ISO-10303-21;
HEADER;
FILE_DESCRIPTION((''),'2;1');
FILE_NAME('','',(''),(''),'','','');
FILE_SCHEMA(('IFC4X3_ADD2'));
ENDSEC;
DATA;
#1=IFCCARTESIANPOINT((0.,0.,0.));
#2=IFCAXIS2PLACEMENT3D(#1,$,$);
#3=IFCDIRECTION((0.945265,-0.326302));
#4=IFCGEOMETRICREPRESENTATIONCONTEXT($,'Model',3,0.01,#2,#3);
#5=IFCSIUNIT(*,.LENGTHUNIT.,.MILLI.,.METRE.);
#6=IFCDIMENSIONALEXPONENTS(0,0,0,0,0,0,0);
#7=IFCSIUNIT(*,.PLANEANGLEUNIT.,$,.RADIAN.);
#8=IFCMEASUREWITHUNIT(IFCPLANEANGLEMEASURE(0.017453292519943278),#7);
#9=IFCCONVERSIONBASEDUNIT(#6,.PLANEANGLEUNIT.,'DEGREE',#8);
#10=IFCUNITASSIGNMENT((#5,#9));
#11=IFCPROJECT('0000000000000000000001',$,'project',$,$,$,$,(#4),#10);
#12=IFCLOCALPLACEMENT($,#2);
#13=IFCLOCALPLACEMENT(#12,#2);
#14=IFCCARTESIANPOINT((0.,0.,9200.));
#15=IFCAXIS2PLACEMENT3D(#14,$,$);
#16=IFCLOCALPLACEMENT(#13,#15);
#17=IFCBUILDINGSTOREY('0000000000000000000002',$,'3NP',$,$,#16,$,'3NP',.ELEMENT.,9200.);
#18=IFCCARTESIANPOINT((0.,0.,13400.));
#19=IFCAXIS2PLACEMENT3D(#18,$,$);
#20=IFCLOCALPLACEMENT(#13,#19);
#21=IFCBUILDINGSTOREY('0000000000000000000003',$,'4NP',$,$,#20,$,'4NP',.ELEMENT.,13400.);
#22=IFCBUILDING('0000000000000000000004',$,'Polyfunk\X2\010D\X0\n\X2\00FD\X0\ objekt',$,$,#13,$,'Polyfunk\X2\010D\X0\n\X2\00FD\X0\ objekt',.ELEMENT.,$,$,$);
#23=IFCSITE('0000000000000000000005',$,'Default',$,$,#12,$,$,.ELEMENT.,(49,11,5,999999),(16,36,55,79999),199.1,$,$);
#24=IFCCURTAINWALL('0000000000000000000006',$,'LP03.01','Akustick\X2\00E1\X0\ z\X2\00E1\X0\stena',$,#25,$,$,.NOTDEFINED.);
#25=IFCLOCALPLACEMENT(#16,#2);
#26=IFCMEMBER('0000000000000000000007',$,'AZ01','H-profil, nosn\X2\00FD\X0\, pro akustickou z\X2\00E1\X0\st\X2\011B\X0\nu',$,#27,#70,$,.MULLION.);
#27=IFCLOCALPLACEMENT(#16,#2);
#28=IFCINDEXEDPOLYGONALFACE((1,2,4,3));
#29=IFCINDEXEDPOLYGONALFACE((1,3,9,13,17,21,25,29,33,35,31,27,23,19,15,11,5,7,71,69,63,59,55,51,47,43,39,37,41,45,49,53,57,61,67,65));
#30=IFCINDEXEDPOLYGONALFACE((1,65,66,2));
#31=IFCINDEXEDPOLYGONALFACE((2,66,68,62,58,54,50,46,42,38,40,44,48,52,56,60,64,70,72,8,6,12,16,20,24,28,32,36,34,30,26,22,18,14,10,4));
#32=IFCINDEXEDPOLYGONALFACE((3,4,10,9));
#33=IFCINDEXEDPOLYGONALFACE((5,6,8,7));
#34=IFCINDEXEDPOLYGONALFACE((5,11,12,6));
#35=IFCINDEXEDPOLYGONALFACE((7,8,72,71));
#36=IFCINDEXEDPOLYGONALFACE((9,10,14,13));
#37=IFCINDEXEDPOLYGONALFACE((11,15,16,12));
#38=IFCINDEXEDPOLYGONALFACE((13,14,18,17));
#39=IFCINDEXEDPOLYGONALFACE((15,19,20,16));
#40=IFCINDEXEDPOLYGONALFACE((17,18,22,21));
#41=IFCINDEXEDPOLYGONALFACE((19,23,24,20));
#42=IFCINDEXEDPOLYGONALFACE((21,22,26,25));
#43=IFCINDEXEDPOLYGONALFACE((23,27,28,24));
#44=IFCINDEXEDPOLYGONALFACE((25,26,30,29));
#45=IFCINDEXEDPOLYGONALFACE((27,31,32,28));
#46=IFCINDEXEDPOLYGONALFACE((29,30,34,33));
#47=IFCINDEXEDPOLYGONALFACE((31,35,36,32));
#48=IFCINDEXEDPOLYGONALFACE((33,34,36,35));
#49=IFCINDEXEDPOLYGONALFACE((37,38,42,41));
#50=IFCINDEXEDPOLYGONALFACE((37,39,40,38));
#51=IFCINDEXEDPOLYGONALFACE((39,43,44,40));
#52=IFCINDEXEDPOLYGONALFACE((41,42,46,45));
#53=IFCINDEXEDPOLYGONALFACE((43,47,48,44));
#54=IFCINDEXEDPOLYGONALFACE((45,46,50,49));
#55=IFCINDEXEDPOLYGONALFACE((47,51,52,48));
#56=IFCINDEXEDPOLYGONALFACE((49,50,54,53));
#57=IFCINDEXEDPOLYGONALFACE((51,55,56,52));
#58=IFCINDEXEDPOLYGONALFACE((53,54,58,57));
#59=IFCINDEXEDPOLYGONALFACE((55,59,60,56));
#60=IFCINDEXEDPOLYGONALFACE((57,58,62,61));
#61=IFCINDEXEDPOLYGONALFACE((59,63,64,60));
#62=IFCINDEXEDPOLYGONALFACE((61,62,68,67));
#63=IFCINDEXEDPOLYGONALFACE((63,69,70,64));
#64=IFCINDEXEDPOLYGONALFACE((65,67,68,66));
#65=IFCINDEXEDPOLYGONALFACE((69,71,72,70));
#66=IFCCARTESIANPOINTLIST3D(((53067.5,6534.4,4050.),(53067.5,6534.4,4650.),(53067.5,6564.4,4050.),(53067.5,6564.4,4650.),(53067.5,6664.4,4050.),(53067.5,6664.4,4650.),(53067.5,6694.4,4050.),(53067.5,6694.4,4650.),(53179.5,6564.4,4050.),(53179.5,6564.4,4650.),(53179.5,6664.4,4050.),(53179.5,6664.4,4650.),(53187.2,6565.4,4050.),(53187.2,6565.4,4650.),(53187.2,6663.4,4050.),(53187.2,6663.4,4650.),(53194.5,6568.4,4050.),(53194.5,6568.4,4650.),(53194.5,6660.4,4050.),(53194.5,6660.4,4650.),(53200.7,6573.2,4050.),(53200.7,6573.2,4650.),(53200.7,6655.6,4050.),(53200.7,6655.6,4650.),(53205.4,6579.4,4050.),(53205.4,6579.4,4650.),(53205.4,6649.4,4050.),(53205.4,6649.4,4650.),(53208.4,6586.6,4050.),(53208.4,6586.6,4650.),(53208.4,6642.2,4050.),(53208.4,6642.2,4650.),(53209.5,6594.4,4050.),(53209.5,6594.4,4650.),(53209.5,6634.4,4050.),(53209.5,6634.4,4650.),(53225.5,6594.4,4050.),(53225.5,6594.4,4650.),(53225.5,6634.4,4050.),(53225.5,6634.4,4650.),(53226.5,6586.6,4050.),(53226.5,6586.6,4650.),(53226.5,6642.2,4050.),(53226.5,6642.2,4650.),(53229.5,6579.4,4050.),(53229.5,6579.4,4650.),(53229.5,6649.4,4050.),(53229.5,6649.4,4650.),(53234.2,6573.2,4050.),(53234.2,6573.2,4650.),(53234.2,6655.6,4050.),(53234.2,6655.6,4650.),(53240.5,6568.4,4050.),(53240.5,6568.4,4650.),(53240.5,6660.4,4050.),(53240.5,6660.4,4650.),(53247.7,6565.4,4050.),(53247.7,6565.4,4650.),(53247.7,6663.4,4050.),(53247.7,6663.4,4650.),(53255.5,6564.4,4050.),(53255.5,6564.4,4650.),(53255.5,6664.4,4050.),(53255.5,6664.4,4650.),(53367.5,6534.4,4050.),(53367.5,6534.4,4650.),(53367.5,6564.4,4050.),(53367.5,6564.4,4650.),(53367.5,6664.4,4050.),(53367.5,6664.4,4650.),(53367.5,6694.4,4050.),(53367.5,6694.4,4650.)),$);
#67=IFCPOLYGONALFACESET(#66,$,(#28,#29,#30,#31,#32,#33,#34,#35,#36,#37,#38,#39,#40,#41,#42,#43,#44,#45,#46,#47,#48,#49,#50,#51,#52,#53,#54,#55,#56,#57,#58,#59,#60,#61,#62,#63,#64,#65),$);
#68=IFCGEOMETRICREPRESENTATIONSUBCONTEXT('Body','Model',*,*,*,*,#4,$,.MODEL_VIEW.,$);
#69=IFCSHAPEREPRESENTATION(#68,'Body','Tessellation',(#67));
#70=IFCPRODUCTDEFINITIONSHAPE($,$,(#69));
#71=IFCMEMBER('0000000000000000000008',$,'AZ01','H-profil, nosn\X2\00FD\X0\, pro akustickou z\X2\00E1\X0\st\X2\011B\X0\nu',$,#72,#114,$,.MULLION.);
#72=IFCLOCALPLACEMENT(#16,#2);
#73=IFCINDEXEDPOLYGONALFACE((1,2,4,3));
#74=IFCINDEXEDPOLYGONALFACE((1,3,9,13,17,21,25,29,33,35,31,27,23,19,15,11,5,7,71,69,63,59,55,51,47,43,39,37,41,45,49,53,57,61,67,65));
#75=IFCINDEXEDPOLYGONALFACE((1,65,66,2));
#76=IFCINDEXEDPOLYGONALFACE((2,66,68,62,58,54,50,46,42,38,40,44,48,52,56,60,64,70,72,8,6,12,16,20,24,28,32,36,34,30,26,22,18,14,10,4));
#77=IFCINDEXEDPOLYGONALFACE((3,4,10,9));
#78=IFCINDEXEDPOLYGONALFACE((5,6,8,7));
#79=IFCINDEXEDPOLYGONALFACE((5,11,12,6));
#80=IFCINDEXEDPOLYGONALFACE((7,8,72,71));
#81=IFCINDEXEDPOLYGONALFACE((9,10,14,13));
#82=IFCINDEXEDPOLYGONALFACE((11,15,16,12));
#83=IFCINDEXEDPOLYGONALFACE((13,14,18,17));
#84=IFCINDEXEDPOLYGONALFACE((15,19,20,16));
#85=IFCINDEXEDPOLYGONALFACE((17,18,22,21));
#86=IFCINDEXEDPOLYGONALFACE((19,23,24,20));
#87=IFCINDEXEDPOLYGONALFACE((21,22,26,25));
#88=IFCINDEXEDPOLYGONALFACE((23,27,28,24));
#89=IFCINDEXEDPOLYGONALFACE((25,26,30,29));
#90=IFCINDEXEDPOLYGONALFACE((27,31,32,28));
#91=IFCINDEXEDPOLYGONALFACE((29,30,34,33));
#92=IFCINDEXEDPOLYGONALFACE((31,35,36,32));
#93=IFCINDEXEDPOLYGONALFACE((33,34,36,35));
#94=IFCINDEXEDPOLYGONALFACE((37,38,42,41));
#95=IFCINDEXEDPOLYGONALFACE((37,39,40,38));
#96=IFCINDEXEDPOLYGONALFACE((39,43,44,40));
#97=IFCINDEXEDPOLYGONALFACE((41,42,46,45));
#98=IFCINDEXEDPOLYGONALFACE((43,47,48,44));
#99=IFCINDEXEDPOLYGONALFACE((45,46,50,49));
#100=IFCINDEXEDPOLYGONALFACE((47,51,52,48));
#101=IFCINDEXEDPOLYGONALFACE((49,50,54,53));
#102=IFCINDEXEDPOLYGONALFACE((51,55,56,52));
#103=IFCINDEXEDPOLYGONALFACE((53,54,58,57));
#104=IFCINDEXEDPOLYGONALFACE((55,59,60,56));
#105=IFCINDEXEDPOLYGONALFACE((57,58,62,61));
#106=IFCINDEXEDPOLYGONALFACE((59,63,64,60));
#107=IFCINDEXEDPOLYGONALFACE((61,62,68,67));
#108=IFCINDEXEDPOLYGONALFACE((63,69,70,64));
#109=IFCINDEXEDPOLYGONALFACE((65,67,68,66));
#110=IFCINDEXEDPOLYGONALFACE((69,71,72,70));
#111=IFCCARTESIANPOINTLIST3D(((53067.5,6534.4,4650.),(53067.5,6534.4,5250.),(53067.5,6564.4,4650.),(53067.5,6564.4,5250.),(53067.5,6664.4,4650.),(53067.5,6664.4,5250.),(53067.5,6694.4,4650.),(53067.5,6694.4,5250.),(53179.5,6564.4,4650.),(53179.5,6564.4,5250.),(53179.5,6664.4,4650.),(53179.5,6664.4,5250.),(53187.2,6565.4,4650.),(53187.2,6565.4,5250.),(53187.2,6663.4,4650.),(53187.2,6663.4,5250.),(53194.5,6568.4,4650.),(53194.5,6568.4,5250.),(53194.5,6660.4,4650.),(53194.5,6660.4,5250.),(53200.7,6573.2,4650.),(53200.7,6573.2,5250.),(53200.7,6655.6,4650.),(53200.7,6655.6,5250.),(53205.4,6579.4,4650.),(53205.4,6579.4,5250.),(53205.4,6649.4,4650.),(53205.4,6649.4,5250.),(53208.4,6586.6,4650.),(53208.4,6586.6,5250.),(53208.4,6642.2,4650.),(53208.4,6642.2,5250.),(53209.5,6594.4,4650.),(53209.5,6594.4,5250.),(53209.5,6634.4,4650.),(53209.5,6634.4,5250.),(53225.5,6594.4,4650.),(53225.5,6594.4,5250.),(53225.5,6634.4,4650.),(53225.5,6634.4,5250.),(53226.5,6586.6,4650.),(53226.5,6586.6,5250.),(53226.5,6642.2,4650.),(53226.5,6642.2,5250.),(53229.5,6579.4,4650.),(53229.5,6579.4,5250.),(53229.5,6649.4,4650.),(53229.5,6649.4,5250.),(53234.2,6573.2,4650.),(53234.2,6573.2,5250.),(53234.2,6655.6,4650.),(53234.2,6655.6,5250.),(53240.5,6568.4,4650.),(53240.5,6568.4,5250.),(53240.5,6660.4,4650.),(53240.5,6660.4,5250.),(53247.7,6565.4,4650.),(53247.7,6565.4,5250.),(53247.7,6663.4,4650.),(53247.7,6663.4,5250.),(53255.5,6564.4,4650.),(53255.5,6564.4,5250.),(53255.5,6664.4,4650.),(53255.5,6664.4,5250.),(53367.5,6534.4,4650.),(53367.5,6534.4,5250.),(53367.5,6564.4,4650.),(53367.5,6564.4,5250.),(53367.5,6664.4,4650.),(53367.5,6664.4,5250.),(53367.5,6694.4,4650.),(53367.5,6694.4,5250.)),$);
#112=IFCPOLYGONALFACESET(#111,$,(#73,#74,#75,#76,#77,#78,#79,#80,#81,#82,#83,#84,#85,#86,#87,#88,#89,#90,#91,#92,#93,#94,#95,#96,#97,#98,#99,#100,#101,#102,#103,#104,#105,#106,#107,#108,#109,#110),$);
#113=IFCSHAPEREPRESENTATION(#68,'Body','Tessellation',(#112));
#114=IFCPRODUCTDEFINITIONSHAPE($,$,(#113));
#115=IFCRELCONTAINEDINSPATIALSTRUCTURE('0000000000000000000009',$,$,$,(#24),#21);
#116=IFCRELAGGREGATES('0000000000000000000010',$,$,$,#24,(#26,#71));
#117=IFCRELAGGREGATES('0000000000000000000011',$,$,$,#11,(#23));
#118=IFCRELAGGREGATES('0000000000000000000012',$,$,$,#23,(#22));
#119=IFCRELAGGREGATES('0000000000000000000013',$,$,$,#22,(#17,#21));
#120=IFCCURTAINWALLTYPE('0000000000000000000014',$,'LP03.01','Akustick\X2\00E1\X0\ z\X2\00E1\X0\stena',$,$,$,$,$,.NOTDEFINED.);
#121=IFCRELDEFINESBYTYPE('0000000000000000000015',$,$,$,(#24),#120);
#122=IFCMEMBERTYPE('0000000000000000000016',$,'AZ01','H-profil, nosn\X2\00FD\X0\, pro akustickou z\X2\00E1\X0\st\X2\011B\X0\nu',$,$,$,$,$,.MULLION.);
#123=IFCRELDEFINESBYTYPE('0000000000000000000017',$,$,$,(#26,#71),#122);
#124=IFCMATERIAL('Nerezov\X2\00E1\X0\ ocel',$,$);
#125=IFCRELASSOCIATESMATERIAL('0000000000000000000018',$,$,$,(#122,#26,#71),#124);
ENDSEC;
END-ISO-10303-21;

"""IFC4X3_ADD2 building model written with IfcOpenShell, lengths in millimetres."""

from ifc_helpers import new_model, entity, si_unit, converted_unit, direction, frame, frame_2d, origin, place, context, subcontext, project, spatial, polyline, circle_curve, parameter, trimmed, segment, composite_curve, outline, extrude, source, transform, mapped, material, material_profile, profile_set, profile_usage, type_object, element, aggregate, save


model = new_model("IFC4X3_ADD2")

# Units and contexts
model_context = context("Model", 3, precision=0.01, world=origin(), true_north=direction((0.945265, -0.326302)))
body_context = subcontext(model_context, "Body", "Model", "MODEL_VIEW")
ifc_project = project(units=[si_unit("LENGTHUNIT", "METRE", prefix="MILLI"), converted_unit("PLANEANGLEUNIT", "DEGREE", entity("IfcPlaneAngleMeasure", 0.017453292519943278), si_unit("PLANEANGLEUNIT", "RADIAN"), dimensions=[0, 0, 0, 0, 0, 0, 0])], contexts=[model_context])

# Site, building, storey
site_placement = place(None, origin())
site = spatial("IfcSite", under=ifc_project, at=site_placement, Name="Default", CompositionType="ELEMENT", RefLatitude=(49, 11, 5, 999999), RefLongitude=(16, 36, 55, 79999), RefElevation=199.1)
building_placement = place(site_placement, origin())
building = spatial("IfcBuilding", under=site, at=building_placement, Name="Polyfunkčný objekt", LongName="Polyfunkčný objekt", CompositionType="ELEMENT")
storey_1_placement = place(building_placement, frame((0.0, 0.0, 9200.0)))
storey_1 = spatial("IfcBuildingStorey", under=building, at=storey_1_placement, Name="3NP", LongName="3NP", CompositionType="ELEMENT", Elevation=9200.0)

# Shared definitions
storey_2_placement = place(building_placement, frame((0.0, 0.0, 13400.0)))
storey_2 = spatial("IfcBuildingStorey", under=building, at=storey_2_placement, Name="4NP", LongName="4NP", CompositionType="ELEMENT", Elevation=13400.0)

# Curtain wall, members
curtain_wall_type_1 = type_object("IfcCurtainWallType", Name="LP03.01", Description="Akustická zástena", PredefinedType="NOTDEFINED")
curtain_wall_1_placement = place(storey_2_placement, frame((0.0, 0.0, -13400.0)))
curtain_wall_1 = element("IfcCurtainWall", 1, at=curtain_wall_1_placement, inside=storey_2, type_object=curtain_wall_type_1, Name="LP03.01", Description="Akustická zástena", PredefinedType="NOTDEFINED")
ifc_material_1 = material(Name="Nerezová ocel")
ifc_material_profile_1 = material_profile(ifc_material_1, outline(composite_curve([segment(polyline([(50.0, -150.0), (80.0, -150.0)]), True, "CONTINUOUS"), segment(polyline([(80.0, -150.0), (80.0, 150.0)]), True, "CONTINUOUS"), segment(polyline([(80.0, 150.0), (50.0, 150.0)]), True, "CONTINUOUS"), segment(polyline([(50.0, 150.0), (50.0, 38.0)]), True, "CONTINUOUS"), segment(trimmed(circle_curve(frame_2d((20.0, 38.0), x_axis=(0.0, 1.0)), 30.0), [parameter(180.0)], [parameter(270.0)], True, "PARAMETER"), False, "CONTINUOUS"), segment(polyline([(20.0, 8.0), (-20.0, 8.0)]), True, "CONTINUOUS"), segment(trimmed(circle_curve(frame_2d((-20.0, 38.0), x_axis=(0.0, 1.0)), 30.0), [parameter(90.0)], [parameter(180.0)], True, "PARAMETER"), False, "CONTINUOUS"), segment(polyline([(-50.0, 38.0), (-50.0, 150.0)]), True, "CONTINUOUS"), segment(polyline([(-50.0, 150.0), (-80.0, 150.0)]), True, "CONTINUOUS"), segment(polyline([(-80.0, 150.0), (-80.0, -150.0)]), True, "CONTINUOUS"), segment(polyline([(-80.0, -150.0), (-50.0, -150.0)]), True, "CONTINUOUS"), segment(polyline([(-50.0, -150.0), (-50.0, -38.0)]), True, "CONTINUOUS"), segment(trimmed(circle_curve(frame_2d((-20.0, -38.0), x_axis=(0.0, 1.0)), 30.0), [parameter(0.0)], [parameter(90.0)], True, "PARAMETER"), False, "CONTINUOUS"), segment(polyline([(-20.0, -8.0), (20.0, -8.0)]), True, "CONTINUOUS"), segment(trimmed(circle_curve(frame_2d((20.0, -38.0), x_axis=(0.0, 1.0)), 30.0), [parameter(270.0)], [parameter(0.0)], True, "PARAMETER"), False, "CONTINUOUS"), segment(polyline([(50.0, -38.0), (50.0, -150.0)]), True, "CONTINUOUS")], self_intersect=False)), Name="Profil zástena")
ifc_profile_set_1 = profile_set([ifc_material_profile_1], Name="Profil zástena")
ifc_profile_usage_1 = profile_usage(ifc_profile_set_1)
member_type_1 = type_object("IfcMemberType", Name="AZ01", Description="H-profil, nosný, pro akustickou zástěnu", PredefinedType="MULLION", material=ifc_profile_set_1)
shared_shape_1 = source(origin(), body_context, "Body", "SweptSolid", [
    extrude(outline(composite_curve([segment(polyline([(50.0, -150.0), (80.0, -150.0)]), True, "CONTINUOUS"), segment(polyline([(80.0, -150.0), (80.0, 150.0)]), True, "CONTINUOUS"), segment(polyline([(80.0, 150.0), (50.0, 150.0)]), True, "CONTINUOUS"), segment(polyline([(50.0, 150.0), (50.0, 38.0)]), True, "CONTINUOUS"), segment(trimmed(circle_curve(frame_2d((20.0, 38.0), x_axis=(0.0, 1.0)), 30.0), [parameter(180.0)], [parameter(270.0)], True, "PARAMETER"), False, "CONTINUOUS"), segment(polyline([(20.0, 8.0), (-20.0, 8.0)]), True, "CONTINUOUS"), segment(trimmed(circle_curve(frame_2d((-20.0, 38.0), x_axis=(0.0, 1.0)), 30.0), [parameter(90.0)], [parameter(180.0)], True, "PARAMETER"), False, "CONTINUOUS"), segment(polyline([(-50.0, 38.0), (-50.0, 150.0)]), True, "CONTINUOUS"), segment(polyline([(-50.0, 150.0), (-80.0, 150.0)]), True, "CONTINUOUS"), segment(polyline([(-80.0, 150.0), (-80.0, -150.0)]), True, "CONTINUOUS"), segment(polyline([(-80.0, -150.0), (-50.0, -150.0)]), True, "CONTINUOUS"), segment(polyline([(-50.0, -150.0), (-50.0, -38.0)]), True, "CONTINUOUS"), segment(trimmed(circle_curve(frame_2d((-20.0, -38.0), x_axis=(0.0, 1.0)), 30.0), [parameter(0.0)], [parameter(90.0)], True, "PARAMETER"), False, "CONTINUOUS"), segment(polyline([(-20.0, -8.0), (20.0, -8.0)]), True, "CONTINUOUS"), segment(trimmed(circle_curve(frame_2d((20.0, -38.0), x_axis=(0.0, 1.0)), 30.0), [parameter(270.0)], [parameter(0.0)], True, "PARAMETER"), False, "CONTINUOUS"), segment(polyline([(50.0, -38.0), (50.0, -150.0)]), True, "CONTINUOUS")], self_intersect=False)), frame((0.0, 0.0, -600.0), z_axis=(0.0, 0.0, 1.0), x_axis=(0.0, -1.0, 0.0)), (0.0, 0.0, 1.0), 600.0),
])
member_1_placement = place(curtain_wall_1_placement, frame((53217.5, 6614.4, 13250.0), z_axis=(0.0, 0.0, -1.0), x_axis=(1.0, 0.0, 0.0)))
member_1 = element("IfcMember", 2, at=member_1_placement, type_object=member_type_1, material=ifc_profile_usage_1, Name="AZ01", Description="H-profil, nosný, pro akustickou zástěnu", PredefinedType="MULLION", context=body_context, shape_type="MappedRepresentation", body=[
    mapped(shared_shape_1, transform((0.0, 0.0, 0.0), scale=1.0)),
])
shared_shape_2 = source(origin(), body_context, "Body", "SweptSolid", [
    extrude(outline(composite_curve([segment(polyline([(50.0, -150.0), (80.0, -150.0)]), True, "CONTINUOUS"), segment(polyline([(80.0, -150.0), (80.0, 150.0)]), True, "CONTINUOUS"), segment(polyline([(80.0, 150.0), (50.0, 150.0)]), True, "CONTINUOUS"), segment(polyline([(50.0, 150.0), (50.0, 38.0)]), True, "CONTINUOUS"), segment(trimmed(circle_curve(frame_2d((20.0, 38.0), x_axis=(0.0, 1.0)), 30.0), [parameter(180.0)], [parameter(270.0)], True, "PARAMETER"), False, "CONTINUOUS"), segment(polyline([(20.0, 8.0), (-20.0, 8.0)]), True, "CONTINUOUS"), segment(trimmed(circle_curve(frame_2d((-20.0, 38.0), x_axis=(0.0, 1.0)), 30.0), [parameter(90.0)], [parameter(180.0)], True, "PARAMETER"), False, "CONTINUOUS"), segment(polyline([(-50.0, 38.0), (-50.0, 150.0)]), True, "CONTINUOUS"), segment(polyline([(-50.0, 150.0), (-80.0, 150.0)]), True, "CONTINUOUS"), segment(polyline([(-80.0, 150.0), (-80.0, -150.0)]), True, "CONTINUOUS"), segment(polyline([(-80.0, -150.0), (-50.0, -150.0)]), True, "CONTINUOUS"), segment(polyline([(-50.0, -150.0), (-50.0, -38.0)]), True, "CONTINUOUS"), segment(trimmed(circle_curve(frame_2d((-20.0, -38.0), x_axis=(0.0, 1.0)), 30.0), [parameter(0.0)], [parameter(90.0)], True, "PARAMETER"), False, "CONTINUOUS"), segment(polyline([(-20.0, -8.0), (20.0, -8.0)]), True, "CONTINUOUS"), segment(trimmed(circle_curve(frame_2d((20.0, -38.0), x_axis=(0.0, 1.0)), 30.0), [parameter(270.0)], [parameter(0.0)], True, "PARAMETER"), False, "CONTINUOUS"), segment(polyline([(50.0, -38.0), (50.0, -150.0)]), True, "CONTINUOUS")], self_intersect=False)), frame((0.0, 0.0, -600.0), z_axis=(0.0, 0.0, 1.0), x_axis=(0.0, -1.0, 0.0)), (0.0, 0.0, 1.0), 600.0),
])
member_2_placement = place(curtain_wall_1_placement, frame((53217.5, 6614.4, 13850.0), z_axis=(0.0, 0.0, -1.0), x_axis=(1.0, 0.0, 0.0)))
member_2 = element("IfcMember", 3, at=member_2_placement, type_object=member_type_1, material=ifc_profile_usage_1, Name="AZ01", Description="H-profil, nosný, pro akustickou zástěnu", PredefinedType="MULLION", context=body_context, shape_type="MappedRepresentation", body=[
    mapped(shared_shape_2, transform((0.0, 0.0, 0.0), scale=1.0)),
])
aggregate(curtain_wall_1, [member_1, member_2])

save(model, "model.ifc")
